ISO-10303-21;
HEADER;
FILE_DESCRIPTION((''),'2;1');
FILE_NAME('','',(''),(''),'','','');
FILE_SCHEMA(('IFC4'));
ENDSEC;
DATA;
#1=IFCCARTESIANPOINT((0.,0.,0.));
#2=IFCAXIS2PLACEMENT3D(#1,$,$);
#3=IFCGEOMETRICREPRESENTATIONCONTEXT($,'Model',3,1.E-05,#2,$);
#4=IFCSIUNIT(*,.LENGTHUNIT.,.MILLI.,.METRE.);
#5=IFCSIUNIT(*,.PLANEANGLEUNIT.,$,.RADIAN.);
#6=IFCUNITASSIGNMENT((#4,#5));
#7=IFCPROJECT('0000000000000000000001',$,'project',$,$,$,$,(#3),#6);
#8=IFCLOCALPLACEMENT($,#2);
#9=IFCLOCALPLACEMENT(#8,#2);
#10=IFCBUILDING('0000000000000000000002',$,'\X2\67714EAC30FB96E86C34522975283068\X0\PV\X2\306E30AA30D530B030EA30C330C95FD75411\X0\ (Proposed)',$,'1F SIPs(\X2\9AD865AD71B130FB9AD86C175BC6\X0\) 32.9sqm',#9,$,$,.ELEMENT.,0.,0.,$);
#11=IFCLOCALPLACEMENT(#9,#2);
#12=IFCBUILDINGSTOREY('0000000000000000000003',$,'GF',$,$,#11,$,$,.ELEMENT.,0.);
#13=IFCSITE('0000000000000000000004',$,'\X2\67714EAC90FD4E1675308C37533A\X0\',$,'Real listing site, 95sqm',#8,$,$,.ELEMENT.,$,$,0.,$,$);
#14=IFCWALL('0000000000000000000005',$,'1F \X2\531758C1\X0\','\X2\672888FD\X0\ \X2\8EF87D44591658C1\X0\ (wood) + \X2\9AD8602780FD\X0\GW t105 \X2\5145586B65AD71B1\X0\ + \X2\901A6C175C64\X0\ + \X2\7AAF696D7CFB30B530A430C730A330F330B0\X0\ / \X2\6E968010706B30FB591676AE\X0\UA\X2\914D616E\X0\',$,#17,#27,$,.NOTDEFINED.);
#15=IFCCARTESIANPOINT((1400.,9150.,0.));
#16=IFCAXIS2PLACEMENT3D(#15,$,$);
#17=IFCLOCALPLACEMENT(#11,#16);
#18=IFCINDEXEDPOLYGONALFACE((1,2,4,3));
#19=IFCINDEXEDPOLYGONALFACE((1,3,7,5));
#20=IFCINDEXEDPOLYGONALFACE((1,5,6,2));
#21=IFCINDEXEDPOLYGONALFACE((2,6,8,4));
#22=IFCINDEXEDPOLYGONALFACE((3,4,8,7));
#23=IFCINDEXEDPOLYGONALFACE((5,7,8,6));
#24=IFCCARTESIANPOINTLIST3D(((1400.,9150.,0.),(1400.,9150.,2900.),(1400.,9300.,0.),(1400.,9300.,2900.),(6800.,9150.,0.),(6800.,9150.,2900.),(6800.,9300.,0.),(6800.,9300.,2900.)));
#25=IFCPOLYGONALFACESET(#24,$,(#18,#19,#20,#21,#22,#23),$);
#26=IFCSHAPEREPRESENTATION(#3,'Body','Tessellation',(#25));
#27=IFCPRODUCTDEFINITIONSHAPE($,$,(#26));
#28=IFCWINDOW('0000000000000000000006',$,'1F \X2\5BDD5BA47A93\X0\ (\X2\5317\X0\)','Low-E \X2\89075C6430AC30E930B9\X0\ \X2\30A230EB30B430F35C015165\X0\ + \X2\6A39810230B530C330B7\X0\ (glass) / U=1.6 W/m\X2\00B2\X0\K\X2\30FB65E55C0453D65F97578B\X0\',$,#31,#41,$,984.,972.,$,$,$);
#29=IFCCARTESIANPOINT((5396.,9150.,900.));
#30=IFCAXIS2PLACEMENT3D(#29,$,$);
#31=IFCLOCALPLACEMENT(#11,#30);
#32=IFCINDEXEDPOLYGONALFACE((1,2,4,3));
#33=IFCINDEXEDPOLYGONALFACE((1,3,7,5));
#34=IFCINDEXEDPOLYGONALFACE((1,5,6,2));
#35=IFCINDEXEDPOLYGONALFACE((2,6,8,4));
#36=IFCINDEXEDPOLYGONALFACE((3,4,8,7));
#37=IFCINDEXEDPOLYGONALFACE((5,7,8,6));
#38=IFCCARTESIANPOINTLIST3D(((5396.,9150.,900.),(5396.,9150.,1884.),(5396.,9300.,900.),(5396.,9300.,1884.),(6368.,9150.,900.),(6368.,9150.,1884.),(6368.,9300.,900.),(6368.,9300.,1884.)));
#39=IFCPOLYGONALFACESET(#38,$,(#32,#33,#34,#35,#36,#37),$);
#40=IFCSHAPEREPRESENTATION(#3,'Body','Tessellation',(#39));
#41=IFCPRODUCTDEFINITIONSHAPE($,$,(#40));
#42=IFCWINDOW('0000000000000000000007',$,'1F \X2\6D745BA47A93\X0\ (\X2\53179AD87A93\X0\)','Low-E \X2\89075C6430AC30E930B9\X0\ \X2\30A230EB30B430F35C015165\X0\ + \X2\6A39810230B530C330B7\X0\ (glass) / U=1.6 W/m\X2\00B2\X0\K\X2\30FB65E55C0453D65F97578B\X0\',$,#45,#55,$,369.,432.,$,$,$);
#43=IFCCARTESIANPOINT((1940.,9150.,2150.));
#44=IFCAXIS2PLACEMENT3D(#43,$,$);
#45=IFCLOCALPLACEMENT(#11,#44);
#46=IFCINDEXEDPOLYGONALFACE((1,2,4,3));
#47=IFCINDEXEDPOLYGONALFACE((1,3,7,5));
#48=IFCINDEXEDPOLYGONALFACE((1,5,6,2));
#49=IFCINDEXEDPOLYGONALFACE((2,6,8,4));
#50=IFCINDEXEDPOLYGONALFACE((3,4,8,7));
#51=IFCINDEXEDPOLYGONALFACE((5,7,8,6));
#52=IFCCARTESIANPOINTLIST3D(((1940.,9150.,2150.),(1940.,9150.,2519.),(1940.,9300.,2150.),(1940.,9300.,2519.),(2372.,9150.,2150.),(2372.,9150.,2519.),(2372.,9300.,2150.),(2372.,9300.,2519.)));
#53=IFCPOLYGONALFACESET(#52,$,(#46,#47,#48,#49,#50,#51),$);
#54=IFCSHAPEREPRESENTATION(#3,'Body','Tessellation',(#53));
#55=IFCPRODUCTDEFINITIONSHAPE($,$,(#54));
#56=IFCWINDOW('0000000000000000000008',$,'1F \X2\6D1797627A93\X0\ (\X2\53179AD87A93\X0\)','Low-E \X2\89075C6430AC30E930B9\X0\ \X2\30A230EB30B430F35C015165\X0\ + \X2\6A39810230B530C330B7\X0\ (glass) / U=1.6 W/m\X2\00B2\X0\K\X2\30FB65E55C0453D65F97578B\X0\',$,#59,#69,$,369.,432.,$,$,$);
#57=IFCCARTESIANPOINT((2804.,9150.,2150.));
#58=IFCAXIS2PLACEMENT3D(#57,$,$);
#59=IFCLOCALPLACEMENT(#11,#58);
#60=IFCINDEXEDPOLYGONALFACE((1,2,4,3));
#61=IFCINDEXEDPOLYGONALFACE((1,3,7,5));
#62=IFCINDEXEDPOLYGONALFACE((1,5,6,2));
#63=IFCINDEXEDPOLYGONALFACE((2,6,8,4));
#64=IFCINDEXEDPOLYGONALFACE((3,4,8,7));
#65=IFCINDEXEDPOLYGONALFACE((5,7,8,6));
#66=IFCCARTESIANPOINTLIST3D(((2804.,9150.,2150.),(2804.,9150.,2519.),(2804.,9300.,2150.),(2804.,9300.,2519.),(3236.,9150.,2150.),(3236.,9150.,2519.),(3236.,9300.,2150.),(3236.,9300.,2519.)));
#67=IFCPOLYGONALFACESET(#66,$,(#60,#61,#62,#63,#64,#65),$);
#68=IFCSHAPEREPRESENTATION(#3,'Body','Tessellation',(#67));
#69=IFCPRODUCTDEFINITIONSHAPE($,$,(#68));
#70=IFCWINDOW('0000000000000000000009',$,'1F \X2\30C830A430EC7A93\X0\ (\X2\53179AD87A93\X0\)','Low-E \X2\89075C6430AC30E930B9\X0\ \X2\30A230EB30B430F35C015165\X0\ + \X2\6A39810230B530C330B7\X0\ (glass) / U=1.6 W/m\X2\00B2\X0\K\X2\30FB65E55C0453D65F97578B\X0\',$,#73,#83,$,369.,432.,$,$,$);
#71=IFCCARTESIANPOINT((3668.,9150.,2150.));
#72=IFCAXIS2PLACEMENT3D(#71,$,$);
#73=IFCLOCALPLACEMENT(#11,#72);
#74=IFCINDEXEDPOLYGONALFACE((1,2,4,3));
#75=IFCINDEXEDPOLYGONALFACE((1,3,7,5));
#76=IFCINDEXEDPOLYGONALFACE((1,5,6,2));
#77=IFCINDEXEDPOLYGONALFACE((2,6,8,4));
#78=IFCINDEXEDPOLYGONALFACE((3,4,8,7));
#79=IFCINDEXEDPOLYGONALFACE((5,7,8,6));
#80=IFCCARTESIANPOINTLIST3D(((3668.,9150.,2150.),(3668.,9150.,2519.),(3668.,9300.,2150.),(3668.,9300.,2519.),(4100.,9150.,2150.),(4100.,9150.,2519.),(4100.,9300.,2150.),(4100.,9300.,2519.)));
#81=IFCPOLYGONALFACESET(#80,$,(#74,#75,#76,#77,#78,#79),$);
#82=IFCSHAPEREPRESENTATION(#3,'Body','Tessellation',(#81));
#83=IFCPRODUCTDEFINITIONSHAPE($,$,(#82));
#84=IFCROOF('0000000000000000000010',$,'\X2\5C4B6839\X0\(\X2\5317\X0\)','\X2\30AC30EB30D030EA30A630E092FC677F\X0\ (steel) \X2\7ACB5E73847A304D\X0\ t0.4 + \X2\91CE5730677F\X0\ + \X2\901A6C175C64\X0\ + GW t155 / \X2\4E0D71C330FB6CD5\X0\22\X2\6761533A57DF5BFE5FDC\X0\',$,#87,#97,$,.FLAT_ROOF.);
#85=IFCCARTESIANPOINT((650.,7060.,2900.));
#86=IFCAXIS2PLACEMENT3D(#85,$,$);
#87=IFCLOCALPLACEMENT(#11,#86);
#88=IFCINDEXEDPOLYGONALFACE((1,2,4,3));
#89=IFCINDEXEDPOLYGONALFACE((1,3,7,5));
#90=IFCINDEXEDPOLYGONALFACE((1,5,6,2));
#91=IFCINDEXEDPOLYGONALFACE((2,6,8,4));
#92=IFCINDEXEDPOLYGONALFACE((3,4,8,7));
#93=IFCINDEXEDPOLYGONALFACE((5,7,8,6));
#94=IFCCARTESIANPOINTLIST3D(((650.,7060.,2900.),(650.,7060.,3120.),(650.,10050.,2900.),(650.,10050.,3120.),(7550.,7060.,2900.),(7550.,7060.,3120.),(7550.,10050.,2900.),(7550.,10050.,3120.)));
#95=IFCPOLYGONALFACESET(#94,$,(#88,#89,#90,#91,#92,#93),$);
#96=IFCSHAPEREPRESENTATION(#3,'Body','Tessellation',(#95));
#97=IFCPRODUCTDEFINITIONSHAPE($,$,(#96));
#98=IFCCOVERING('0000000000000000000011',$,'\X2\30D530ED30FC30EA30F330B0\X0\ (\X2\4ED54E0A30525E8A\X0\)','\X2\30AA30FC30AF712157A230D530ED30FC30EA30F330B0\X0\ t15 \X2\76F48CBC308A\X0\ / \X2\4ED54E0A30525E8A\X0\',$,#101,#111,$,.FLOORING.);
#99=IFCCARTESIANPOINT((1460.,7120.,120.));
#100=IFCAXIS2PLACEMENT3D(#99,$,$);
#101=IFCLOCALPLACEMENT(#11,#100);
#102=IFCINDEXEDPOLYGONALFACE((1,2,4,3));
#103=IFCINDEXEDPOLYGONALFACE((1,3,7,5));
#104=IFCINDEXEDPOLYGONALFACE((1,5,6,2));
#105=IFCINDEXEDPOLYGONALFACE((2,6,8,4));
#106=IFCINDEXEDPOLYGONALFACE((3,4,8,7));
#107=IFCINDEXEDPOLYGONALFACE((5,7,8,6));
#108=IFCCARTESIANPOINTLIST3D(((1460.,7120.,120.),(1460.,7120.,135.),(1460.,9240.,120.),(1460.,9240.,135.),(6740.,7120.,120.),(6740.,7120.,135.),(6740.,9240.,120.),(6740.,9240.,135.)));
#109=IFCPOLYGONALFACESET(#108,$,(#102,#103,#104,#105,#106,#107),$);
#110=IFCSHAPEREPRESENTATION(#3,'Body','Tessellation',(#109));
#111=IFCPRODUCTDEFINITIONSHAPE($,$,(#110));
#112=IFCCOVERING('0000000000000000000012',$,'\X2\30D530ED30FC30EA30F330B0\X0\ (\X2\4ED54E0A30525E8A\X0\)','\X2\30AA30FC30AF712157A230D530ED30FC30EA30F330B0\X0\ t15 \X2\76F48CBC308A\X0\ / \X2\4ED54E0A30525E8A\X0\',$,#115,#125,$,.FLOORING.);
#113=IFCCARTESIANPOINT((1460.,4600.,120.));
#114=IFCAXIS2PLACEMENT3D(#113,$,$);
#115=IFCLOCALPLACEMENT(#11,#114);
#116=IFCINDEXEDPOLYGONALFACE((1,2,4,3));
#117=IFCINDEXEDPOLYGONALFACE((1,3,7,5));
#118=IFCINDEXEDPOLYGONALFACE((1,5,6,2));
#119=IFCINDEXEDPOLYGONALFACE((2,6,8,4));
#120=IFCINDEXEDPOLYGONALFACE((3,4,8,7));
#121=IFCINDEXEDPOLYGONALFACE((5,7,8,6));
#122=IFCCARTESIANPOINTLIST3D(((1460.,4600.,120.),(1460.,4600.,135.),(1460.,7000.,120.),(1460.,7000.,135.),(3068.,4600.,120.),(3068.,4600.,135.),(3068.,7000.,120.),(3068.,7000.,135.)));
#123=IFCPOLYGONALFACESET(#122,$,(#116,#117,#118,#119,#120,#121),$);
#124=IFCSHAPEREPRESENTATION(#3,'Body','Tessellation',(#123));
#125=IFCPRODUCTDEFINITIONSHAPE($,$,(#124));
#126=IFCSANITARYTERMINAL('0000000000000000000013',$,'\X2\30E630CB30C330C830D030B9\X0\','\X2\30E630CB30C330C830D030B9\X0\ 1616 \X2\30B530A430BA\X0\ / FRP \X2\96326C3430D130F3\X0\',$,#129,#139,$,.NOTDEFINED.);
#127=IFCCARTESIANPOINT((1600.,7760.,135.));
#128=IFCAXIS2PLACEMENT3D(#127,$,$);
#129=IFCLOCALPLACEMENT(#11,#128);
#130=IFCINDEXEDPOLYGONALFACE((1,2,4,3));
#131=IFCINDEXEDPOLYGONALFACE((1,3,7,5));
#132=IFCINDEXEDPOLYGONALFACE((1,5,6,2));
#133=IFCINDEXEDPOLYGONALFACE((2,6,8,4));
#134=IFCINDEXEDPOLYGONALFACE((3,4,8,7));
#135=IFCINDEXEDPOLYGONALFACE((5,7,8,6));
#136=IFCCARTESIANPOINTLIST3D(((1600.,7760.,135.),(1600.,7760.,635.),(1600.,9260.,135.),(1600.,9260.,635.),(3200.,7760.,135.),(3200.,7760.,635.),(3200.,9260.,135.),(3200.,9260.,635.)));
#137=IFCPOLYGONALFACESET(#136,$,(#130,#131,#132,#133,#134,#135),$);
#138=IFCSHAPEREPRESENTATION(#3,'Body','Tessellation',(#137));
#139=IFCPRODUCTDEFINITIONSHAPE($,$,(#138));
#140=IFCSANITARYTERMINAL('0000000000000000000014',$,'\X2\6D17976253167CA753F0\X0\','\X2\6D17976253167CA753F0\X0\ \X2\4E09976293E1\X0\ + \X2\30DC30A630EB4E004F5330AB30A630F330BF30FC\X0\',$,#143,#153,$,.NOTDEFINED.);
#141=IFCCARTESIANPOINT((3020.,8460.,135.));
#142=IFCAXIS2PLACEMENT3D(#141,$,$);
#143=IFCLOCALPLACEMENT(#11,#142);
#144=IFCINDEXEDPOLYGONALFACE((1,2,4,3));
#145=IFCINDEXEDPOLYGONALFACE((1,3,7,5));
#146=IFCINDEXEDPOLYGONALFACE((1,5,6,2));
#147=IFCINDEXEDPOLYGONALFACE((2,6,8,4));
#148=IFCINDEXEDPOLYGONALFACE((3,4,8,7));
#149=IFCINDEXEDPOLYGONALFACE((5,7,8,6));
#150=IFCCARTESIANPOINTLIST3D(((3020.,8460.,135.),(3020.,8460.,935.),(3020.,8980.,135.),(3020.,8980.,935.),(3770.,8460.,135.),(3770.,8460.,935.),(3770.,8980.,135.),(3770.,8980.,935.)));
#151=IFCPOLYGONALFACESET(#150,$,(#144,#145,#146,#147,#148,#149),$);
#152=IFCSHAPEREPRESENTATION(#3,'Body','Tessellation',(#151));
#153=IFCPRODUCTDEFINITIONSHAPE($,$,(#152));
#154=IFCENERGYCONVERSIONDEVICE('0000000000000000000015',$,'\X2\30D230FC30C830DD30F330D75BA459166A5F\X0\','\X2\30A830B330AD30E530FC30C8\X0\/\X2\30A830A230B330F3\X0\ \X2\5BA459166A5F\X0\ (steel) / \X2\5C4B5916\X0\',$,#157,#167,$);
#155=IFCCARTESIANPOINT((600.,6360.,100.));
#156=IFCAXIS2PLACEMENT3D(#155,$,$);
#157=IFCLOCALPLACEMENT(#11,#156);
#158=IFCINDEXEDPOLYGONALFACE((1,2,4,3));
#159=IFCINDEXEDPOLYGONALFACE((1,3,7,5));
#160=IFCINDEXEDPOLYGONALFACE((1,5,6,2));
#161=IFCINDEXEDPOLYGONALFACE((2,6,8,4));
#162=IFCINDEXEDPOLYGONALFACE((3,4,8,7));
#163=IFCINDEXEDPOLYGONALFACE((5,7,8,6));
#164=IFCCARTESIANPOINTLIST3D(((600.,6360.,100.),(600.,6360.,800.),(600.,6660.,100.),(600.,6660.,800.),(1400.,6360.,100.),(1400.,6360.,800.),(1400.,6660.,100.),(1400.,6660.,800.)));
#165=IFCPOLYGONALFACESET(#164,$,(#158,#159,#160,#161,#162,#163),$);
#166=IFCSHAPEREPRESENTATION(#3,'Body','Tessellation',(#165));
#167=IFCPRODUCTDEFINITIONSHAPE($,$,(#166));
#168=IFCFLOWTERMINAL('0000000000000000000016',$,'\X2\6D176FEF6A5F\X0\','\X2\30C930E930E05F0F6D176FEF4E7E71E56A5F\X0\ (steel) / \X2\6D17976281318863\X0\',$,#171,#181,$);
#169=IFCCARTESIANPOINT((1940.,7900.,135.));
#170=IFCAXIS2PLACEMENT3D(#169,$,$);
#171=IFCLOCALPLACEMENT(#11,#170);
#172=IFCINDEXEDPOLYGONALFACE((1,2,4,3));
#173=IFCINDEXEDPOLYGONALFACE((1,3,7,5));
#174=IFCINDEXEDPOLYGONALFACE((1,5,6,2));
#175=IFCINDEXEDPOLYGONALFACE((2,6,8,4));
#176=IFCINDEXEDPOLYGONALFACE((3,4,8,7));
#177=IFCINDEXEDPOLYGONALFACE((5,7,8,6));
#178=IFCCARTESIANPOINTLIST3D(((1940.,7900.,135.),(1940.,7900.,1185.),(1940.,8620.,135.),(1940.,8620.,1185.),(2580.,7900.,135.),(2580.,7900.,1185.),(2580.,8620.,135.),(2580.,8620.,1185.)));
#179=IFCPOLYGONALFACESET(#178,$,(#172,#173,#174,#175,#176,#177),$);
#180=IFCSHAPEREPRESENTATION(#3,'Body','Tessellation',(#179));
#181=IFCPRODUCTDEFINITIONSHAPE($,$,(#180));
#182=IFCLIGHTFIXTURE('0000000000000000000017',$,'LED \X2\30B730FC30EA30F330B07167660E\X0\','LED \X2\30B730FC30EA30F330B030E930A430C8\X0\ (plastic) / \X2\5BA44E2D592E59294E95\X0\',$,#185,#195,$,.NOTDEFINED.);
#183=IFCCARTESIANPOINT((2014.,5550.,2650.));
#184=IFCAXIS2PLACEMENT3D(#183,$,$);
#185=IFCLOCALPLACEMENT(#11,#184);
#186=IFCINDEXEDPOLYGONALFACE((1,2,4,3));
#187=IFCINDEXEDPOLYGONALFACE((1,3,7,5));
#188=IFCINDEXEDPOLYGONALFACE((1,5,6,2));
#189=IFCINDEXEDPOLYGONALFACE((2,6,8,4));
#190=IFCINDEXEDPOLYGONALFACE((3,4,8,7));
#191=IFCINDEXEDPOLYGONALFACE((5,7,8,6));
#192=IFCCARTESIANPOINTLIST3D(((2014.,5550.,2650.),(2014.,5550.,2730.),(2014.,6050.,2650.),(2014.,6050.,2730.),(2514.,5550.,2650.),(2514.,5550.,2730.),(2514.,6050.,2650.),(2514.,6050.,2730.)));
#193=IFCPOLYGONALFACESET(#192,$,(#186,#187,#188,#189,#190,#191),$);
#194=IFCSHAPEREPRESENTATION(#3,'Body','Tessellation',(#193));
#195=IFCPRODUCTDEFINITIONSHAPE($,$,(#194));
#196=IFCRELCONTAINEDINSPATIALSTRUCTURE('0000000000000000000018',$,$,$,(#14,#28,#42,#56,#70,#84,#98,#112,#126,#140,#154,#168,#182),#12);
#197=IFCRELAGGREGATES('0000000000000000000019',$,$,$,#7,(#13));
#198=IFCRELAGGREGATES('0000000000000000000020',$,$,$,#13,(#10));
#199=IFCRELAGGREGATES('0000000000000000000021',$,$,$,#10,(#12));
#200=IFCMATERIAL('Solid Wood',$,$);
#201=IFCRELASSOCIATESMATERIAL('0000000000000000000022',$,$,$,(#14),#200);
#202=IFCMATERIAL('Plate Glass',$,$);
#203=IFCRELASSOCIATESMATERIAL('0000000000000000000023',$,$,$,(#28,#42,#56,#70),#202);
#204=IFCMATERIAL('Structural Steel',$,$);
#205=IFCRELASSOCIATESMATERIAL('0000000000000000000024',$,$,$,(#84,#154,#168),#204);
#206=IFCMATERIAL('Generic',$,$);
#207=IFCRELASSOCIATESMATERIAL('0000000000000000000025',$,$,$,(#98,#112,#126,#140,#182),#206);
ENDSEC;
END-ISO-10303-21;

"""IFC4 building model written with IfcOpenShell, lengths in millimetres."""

from ifc_helpers import new_model, si_unit, frame, frame_2d, origin, place, context, project, spatial, rectangle, extrude, material, element, fill, save


model = new_model("IFC4")

# Units and contexts
model_context = context("Model", 3, precision=1e-05, world=origin())
ifc_project = project(units=[si_unit("LENGTHUNIT", "METRE", prefix="MILLI"), si_unit("PLANEANGLEUNIT", "RADIAN")], contexts=[model_context])

# Site, building, storey
site_placement = place(None, origin())
site = spatial("IfcSite", under=ifc_project, at=site_placement, Name="東京都世田谷区", ObjectType="Real listing site, 95sqm", CompositionType="ELEMENT", RefElevation=0.0)
building_placement = place(site_placement, origin())
building = spatial("IfcBuilding", under=site, at=building_placement, Name="東京・雨水利用とPVのオフグリッド志向 (Proposed)", ObjectType="1F SIPs(高断熱・高気密) 32.9sqm", CompositionType="ELEMENT", ElevationOfRefHeight=0.0, ElevationOfTerrain=0.0)
storey_placement = place(building_placement, origin())
storey = spatial("IfcBuildingStorey", under=building, at=storey_placement, Name="GF", CompositionType="ELEMENT", Elevation=0.0)

# Shared definitions
ifc_material_1 = material(Name="Solid Wood")

# Wall, openings, windows
wall_1_placement = place(storey_placement, frame((1400.0, 9150.0, 0.0)))
wall_1 = element("IfcWall", 1, at=wall_1_placement, inside=storey, material=ifc_material_1, Name="1F 北壁", Description="木製 軸組外壁 (wood) + 高性能GW t105 充填断熱 + 通気層 + 窯業系サイディング / 準耐火・外皮UA配慮", PredefinedType="NOTDEFINED", context=model_context, shape_type="SweptSolid", body=[
    extrude(rectangle(XDim=5400.0, YDim=150.0, at=frame_2d((2700.0, 75.0))), frame((1400.0, 9150.0, 0.0)), (0.0, 0.0, 1.0), 2900.0),
])
opening_1_placement = place(storey_placement, frame((5396.0, 9150.0, 900.0)))
opening_1 = element("IfcOpeningElement", 2, at=opening_1_placement, cuts=wall_1, PredefinedType="NOTDEFINED", context=model_context, shape_type="SweptSolid", body=[
    extrude(rectangle(XDim=972.0, YDim=150.0, at=frame_2d((486.0, 75.0))), frame((5396.0, 9150.0, 900.0)), (0.0, 0.0, 1.0), 984.0),
])
opening_2_placement = place(storey_placement, frame((1940.0, 9150.0, 2150.0)))
opening_2 = element("IfcOpeningElement", 3, at=opening_2_placement, cuts=wall_1, PredefinedType="NOTDEFINED", context=model_context, shape_type="SweptSolid", body=[
    extrude(rectangle(XDim=432.0, YDim=150.0, at=frame_2d((216.0, 75.0))), frame((1940.0, 9150.0, 2150.0)), (0.0, 0.0, 1.0), 369.0),
])
opening_3_placement = place(storey_placement, frame((2804.0, 9150.0, 2150.0)))
opening_3 = element("IfcOpeningElement", 4, at=opening_3_placement, cuts=wall_1, PredefinedType="NOTDEFINED", context=model_context, shape_type="SweptSolid", body=[
    extrude(rectangle(XDim=432.0, YDim=150.0, at=frame_2d((216.0, 75.0))), frame((2804.0, 9150.0, 2150.0)), (0.0, 0.0, 1.0), 369.0),
])
opening_4_placement = place(storey_placement, frame((3668.0, 9150.0, 2150.0)))
opening_4 = element("IfcOpeningElement", 5, at=opening_4_placement, cuts=wall_1, PredefinedType="NOTDEFINED", context=model_context, shape_type="SweptSolid", body=[
    extrude(rectangle(XDim=432.0, YDim=150.0, at=frame_2d((216.0, 75.0))), frame((3668.0, 9150.0, 2150.0)), (0.0, 0.0, 1.0), 369.0),
])
ifc_material_2 = material(Name="Plate Glass")
window_1_placement = place(storey_placement, frame((5396.0, 9150.0, 900.0)))
window_1 = element("IfcWindow", 6, at=window_1_placement, inside=storey, material=ifc_material_2, Name="1F 寝室窓 (北)", Description="Low-E 複層ガラス アルゴン封入 + 樹脂サッシ (glass) / U=1.6 W/m²K・日射取得型", OverallHeight=984.0, OverallWidth=972.0, context=model_context, shape_type="SweptSolid", body=[
    extrude(rectangle(XDim=972.0, YDim=150.0, at=frame_2d((486.0, 75.0))), frame((5396.0, 9150.0, 900.0)), (0.0, 0.0, 1.0), 984.0),
])
fill(opening_1, window_1)
window_2_placement = place(storey_placement, frame((1940.0, 9150.0, 2150.0)))
window_2 = element("IfcWindow", 7, at=window_2_placement, inside=storey, material=ifc_material_2, Name="1F 浴室窓 (北高窓)", Description="Low-E 複層ガラス アルゴン封入 + 樹脂サッシ (glass) / U=1.6 W/m²K・日射取得型", OverallHeight=369.0, OverallWidth=432.0, context=model_context, shape_type="SweptSolid", body=[
    extrude(rectangle(XDim=432.0, YDim=150.0, at=frame_2d((216.0, 75.0))), frame((1940.0, 9150.0, 2150.0)), (0.0, 0.0, 1.0), 369.0),
])
fill(opening_2, window_2)
window_3_placement = place(storey_placement, frame((2804.0, 9150.0, 2150.0)))
window_3 = element("IfcWindow", 8, at=window_3_placement, inside=storey, material=ifc_material_2, Name="1F 洗面窓 (北高窓)", Description="Low-E 複層ガラス アルゴン封入 + 樹脂サッシ (glass) / U=1.6 W/m²K・日射取得型", OverallHeight=369.0, OverallWidth=432.0, context=model_context, shape_type="SweptSolid", body=[
    extrude(rectangle(XDim=432.0, YDim=150.0, at=frame_2d((216.0, 75.0))), frame((2804.0, 9150.0, 2150.0)), (0.0, 0.0, 1.0), 369.0),
])
fill(opening_3, window_3)
window_4_placement = place(storey_placement, frame((3668.0, 9150.0, 2150.0)))
window_4 = element("IfcWindow", 9, at=window_4_placement, inside=storey, material=ifc_material_2, Name="1F トイレ窓 (北高窓)", Description="Low-E 複層ガラス アルゴン封入 + 樹脂サッシ (glass) / U=1.6 W/m²K・日射取得型", OverallHeight=369.0, OverallWidth=432.0, context=model_context, shape_type="SweptSolid", body=[
    extrude(rectangle(XDim=432.0, YDim=150.0, at=frame_2d((216.0, 75.0))), frame((3668.0, 9150.0, 2150.0)), (0.0, 0.0, 1.0), 369.0),
])
fill(opening_4, window_4)

# Roof
ifc_material_3 = material(Name="Structural Steel")
roof_placement = place(storey_placement, frame((650.0, 7060.0, 2900.0)))
element("IfcRoof", 10, at=roof_placement, inside=storey, material=ifc_material_3, Name="屋根(北)", Description="ガルバリウム鋼板 (steel) 立平葺き t0.4 + 野地板 + 通気層 + GW t155 / 不燃・法22条区域対応", PredefinedType="FLAT_ROOF", context=model_context, shape_type="SweptSolid", body=[
    extrude(rectangle(XDim=6900.0, YDim=2990.0, at=frame_2d((3450.0, 1495.0))), frame((650.0, 7060.0, 2900.0)), (0.0, 0.0, 1.0), 220.0),
])

# Coverings
ifc_material_4 = material(Name="Generic")
covering_1_placement = place(storey_placement, frame((1460.0, 7120.0, 120.0)))
element("IfcCovering", 11, at=covering_1_placement, inside=storey, material=ifc_material_4, Name="フローリング (仕上げ床)", Description="オーク無垢フローリング t15 直貼り / 仕上げ床", PredefinedType="FLOORING", context=model_context, shape_type="SweptSolid", body=[
    extrude(rectangle(XDim=5280.0, YDim=2120.0, at=frame_2d((2640.0, 1060.0))), frame((1460.0, 7120.0, 120.0)), (0.0, 0.0, 1.0), 15.0),
])
covering_2_placement = place(storey_placement, frame((1460.0, 4600.0, 120.0)))
element("IfcCovering", 12, at=covering_2_placement, inside=storey, material=ifc_material_4, Name="フローリング (仕上げ床)", Description="オーク無垢フローリング t15 直貼り / 仕上げ床", PredefinedType="FLOORING", context=model_context, shape_type="SweptSolid", body=[
    extrude(rectangle(XDim=1608.0, YDim=2400.0, at=frame_2d((804.0, 1200.0))), frame((1460.0, 4600.0, 120.0)), (0.0, 0.0, 1.0), 15.0),
])

# Sanitary terminals
sanitary_terminal_1_placement = place(storey_placement, frame((1600.0, 7760.0, 135.0)))
element("IfcSanitaryTerminal", 13, at=sanitary_terminal_1_placement, inside=storey, material=ifc_material_4, Name="ユニットバス", Description="ユニットバス 1616 サイズ / FRP 防水パン", PredefinedType="NOTDEFINED", context=model_context, shape_type="SweptSolid", body=[
    extrude(rectangle(XDim=1600.0, YDim=1500.0, at=frame_2d((800.0, 750.0))), frame((1600.0, 7760.0, 135.0)), (0.0, 0.0, 1.0), 500.0),
])
sanitary_terminal_2_placement = place(storey_placement, frame((3020.0, 8460.0, 135.0)))
element("IfcSanitaryTerminal", 14, at=sanitary_terminal_2_placement, inside=storey, material=ifc_material_4, Name="洗面化粧台", Description="洗面化粧台 三面鏡 + ボウル一体カウンター", PredefinedType="NOTDEFINED", context=model_context, shape_type="SweptSolid", body=[
    extrude(rectangle(XDim=750.0, YDim=520.0, at=frame_2d((375.0, 260.0))), frame((3020.0, 8460.0, 135.0)), (0.0, 0.0, 1.0), 800.0),
])

# Energy conversion device
energy_conversion_device_placement = place(storey_placement, frame((600.0, 6360.0, 100.0)))
element("IfcEnergyConversionDevice", 15, at=energy_conversion_device_placement, inside=storey, material=ifc_material_3, Name="ヒートポンプ室外機", Description="エコキュート/エアコン 室外機 (steel) / 屋外", context=model_context, shape_type="SweptSolid", body=[
    extrude(rectangle(XDim=800.0, YDim=300.0, at=frame_2d((400.0, 150.0))), frame((600.0, 6360.0, 100.0)), (0.0, 0.0, 1.0), 700.0),
])

# Flow terminal
flow_terminal_placement = place(storey_placement, frame((1940.0, 7900.0, 135.0)))
element("IfcFlowTerminal", 16, at=flow_terminal_placement, inside=storey, material=ifc_material_3, Name="洗濯機", Description="ドラム式洗濯乾燥機 (steel) / 洗面脱衣", context=model_context, shape_type="SweptSolid", body=[
    extrude(rectangle(XDim=640.0, YDim=720.0, at=frame_2d((320.0, 360.0))), frame((1940.0, 7900.0, 135.0)), (0.0, 0.0, 1.0), 1050.0),
])

# Light fixture
light_fixture_placement = place(storey_placement, frame((2014.0, 5550.0, 2650.0)))
element("IfcLightFixture", 17, at=light_fixture_placement, inside=storey, material=ifc_material_4, Name="LED シーリング照明", Description="LED シーリングライト (plastic) / 室中央天井", PredefinedType="NOTDEFINED", context=model_context, shape_type="SweptSolid", body=[
    extrude(rectangle(XDim=500.0, YDim=500.0, at=frame_2d((250.0, 250.0))), frame((2014.0, 5550.0, 2650.0)), (0.0, 0.0, 1.0), 80.0),
])

save(model, "model.ifc")
